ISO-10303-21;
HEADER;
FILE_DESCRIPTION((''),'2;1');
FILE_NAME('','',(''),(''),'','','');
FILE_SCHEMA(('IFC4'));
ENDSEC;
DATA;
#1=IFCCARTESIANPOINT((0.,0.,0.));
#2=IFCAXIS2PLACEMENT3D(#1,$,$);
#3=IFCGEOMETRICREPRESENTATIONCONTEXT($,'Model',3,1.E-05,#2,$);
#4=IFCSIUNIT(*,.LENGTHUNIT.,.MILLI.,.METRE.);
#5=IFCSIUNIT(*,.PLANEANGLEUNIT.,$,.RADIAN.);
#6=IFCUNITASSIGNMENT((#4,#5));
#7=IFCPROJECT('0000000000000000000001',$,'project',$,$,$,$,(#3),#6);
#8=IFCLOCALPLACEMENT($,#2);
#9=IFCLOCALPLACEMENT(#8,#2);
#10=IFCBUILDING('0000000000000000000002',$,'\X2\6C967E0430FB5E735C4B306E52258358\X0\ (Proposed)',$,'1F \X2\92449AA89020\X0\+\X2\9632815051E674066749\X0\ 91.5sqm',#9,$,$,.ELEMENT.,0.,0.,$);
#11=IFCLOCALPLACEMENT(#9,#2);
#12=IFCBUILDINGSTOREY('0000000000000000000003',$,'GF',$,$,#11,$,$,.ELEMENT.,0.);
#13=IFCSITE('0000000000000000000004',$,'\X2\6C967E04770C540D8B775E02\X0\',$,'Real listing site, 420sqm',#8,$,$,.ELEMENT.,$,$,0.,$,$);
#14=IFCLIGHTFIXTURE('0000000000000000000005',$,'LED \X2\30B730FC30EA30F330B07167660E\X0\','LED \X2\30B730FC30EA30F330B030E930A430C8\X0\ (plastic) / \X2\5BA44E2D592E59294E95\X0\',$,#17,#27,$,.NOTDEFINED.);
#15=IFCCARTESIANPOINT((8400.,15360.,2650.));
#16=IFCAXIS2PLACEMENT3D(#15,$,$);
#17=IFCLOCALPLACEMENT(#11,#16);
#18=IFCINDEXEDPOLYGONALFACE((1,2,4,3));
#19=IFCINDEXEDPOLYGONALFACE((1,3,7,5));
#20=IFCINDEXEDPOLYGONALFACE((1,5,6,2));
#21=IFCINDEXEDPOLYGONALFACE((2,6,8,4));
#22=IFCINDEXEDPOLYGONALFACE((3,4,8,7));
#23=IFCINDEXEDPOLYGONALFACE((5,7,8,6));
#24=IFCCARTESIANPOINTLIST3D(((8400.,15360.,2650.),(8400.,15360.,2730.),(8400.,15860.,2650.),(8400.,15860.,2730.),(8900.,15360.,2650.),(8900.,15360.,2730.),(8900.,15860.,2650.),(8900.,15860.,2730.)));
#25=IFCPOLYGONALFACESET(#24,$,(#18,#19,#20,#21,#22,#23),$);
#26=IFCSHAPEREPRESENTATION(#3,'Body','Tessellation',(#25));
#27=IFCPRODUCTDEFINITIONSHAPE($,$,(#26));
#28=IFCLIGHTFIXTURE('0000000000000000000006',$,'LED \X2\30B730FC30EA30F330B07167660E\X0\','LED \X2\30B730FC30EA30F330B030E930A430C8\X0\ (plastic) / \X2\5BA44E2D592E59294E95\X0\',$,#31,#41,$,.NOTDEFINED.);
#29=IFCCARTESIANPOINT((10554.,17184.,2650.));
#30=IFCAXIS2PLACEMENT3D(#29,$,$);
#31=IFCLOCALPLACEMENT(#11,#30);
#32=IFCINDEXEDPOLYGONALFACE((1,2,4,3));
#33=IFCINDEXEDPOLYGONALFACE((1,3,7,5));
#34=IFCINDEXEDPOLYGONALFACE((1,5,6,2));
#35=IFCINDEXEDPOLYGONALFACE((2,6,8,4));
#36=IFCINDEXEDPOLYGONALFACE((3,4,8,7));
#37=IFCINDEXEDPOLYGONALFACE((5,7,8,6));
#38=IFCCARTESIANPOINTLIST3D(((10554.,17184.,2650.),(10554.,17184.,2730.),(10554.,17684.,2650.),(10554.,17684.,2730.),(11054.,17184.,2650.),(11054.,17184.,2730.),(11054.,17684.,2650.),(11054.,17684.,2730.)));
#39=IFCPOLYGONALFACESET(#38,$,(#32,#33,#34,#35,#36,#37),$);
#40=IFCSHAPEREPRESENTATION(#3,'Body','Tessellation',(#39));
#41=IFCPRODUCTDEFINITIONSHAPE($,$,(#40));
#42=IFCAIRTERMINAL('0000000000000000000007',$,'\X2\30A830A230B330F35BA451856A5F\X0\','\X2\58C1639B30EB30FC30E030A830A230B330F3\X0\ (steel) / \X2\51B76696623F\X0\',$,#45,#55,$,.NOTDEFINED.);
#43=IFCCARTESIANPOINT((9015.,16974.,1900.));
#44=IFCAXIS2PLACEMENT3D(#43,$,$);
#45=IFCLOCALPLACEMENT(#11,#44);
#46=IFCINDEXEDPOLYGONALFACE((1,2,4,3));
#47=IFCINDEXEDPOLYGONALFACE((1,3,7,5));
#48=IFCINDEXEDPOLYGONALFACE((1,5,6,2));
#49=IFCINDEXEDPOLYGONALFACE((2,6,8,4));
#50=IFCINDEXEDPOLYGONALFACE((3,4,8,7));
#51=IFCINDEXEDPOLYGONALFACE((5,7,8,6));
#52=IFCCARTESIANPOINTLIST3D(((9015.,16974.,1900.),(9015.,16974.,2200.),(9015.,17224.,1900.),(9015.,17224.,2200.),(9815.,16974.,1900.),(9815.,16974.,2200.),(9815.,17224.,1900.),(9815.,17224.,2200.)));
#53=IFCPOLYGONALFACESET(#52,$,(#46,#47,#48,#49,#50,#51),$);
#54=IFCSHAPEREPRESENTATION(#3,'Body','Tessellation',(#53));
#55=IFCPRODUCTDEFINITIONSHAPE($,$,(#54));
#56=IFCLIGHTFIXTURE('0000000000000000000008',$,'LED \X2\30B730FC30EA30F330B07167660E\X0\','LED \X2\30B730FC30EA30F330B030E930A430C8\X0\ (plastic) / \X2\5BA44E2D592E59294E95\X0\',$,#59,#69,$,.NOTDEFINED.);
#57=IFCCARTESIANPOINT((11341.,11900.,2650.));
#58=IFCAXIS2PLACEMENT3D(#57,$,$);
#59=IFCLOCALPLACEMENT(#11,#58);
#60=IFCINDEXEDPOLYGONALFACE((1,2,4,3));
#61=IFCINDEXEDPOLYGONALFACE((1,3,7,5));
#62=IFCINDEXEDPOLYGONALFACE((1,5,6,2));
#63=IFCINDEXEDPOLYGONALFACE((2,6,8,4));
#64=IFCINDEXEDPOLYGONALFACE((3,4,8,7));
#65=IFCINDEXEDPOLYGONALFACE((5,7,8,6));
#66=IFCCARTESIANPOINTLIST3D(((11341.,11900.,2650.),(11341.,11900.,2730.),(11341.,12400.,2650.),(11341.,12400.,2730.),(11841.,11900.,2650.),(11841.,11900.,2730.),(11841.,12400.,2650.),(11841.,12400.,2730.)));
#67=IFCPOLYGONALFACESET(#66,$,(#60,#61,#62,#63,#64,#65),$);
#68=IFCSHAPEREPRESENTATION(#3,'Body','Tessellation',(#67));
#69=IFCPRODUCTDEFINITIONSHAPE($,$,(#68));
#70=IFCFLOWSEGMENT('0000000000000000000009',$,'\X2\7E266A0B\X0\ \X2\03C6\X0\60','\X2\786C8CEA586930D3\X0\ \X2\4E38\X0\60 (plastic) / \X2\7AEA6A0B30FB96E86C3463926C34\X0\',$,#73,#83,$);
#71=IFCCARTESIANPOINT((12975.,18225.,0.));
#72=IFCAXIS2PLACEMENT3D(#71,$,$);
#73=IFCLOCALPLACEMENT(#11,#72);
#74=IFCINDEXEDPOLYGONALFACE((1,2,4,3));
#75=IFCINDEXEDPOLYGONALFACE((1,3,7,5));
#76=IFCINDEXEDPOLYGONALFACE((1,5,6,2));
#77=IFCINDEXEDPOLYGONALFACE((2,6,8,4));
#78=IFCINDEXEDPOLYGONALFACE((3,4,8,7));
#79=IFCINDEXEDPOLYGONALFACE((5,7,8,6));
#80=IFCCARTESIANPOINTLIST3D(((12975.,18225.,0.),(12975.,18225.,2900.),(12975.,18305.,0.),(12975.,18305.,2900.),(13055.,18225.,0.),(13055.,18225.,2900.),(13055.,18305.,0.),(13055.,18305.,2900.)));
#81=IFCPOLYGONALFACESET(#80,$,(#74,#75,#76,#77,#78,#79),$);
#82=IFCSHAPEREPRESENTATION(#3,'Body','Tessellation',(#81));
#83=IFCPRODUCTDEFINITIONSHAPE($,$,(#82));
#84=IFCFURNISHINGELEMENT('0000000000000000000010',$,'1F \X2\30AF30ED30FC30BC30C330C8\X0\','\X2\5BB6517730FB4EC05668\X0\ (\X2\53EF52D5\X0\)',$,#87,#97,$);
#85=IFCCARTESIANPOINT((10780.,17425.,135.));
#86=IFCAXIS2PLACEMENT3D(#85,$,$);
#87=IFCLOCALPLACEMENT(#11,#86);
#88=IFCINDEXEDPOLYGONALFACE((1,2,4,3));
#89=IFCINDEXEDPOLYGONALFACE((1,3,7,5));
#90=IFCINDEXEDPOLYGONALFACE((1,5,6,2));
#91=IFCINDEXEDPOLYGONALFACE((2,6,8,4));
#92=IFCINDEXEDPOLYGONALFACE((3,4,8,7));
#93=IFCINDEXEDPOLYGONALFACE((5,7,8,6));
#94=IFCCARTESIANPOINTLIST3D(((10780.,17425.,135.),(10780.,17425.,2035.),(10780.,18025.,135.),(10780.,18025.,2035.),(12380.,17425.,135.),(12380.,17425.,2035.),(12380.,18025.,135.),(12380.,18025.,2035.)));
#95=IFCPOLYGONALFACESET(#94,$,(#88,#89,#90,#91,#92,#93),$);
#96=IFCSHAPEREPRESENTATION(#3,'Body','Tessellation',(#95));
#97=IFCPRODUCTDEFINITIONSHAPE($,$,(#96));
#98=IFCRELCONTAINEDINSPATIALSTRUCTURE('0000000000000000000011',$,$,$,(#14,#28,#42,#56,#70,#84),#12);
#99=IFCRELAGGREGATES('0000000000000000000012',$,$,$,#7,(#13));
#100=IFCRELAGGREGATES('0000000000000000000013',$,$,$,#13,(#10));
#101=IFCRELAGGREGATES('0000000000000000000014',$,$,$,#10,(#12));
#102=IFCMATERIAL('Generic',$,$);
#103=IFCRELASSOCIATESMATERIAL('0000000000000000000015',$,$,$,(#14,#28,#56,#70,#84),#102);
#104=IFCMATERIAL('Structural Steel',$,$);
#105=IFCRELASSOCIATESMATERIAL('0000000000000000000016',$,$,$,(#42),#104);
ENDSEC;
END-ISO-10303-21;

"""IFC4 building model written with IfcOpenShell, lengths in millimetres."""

from ifc_helpers import new_model, si_unit, frame, frame_2d, origin, place, context, project, spatial, rectangle, extrude, material, element, save


model = new_model("IFC4")

# Units and contexts
model_context = context("Model", 3, precision=1e-05, world=origin())
ifc_project = project(units=[si_unit("LENGTHUNIT", "METRE", prefix="MILLI"), si_unit("PLANEANGLEUNIT", "RADIAN")], contexts=[model_context])

# Site, building, storey
site_placement = place(None, origin())
site = spatial("IfcSite", under=ifc_project, at=site_placement, Name="沖縄県名護市", ObjectType="Real listing site, 420sqm", CompositionType="ELEMENT", RefElevation=0.0)
building_placement = place(site_placement, origin())
building = spatial("IfcBuilding", under=site, at=building_placement, Name="沖縄・平屋の別荘 (Proposed)", ObjectType="1F 鉄骨造+防腐処理杉 91.5sqm", CompositionType="ELEMENT", ElevationOfRefHeight=0.0, ElevationOfTerrain=0.0)
storey_placement = place(building_placement, origin())
storey = spatial("IfcBuildingStorey", under=building, at=storey_placement, Name="GF", CompositionType="ELEMENT", Elevation=0.0)

# Shared definitions
ifc_material_1 = material(Name="Generic")

# Shared definitions
ifc_material_2 = material(Name="Structural Steel")

# Light fixtures
light_fixture_1_placement = place(storey_placement, frame((8400.0, 15360.0, 2650.0)))
element("IfcLightFixture", 1, at=light_fixture_1_placement, inside=storey, material=ifc_material_1, Name="LED シーリング照明", Description="LED シーリングライト (plastic) / 室中央天井", PredefinedType="NOTDEFINED", context=model_context, shape_type="SweptSolid", body=[
    extrude(rectangle(XDim=500.0, YDim=500.0, at=frame_2d((250.0, 250.0))), frame((8400.0, 15360.0, 2650.0)), (0.0, 0.0, 1.0), 80.0),
])
light_fixture_2_placement = place(storey_placement, frame((10554.0, 17184.0, 2650.0)))
element("IfcLightFixture", 2, at=light_fixture_2_placement, inside=storey, material=ifc_material_1, Name="LED シーリング照明", Description="LED シーリングライト (plastic) / 室中央天井", PredefinedType="NOTDEFINED", context=model_context, shape_type="SweptSolid", body=[
    extrude(rectangle(XDim=500.0, YDim=500.0, at=frame_2d((250.0, 250.0))), frame((10554.0, 17184.0, 2650.0)), (0.0, 0.0, 1.0), 80.0),
])

# Air terminal
air_terminal_placement = place(storey_placement, frame((9015.0, 16974.0, 1900.0)))
element("IfcAirTerminal", 3, at=air_terminal_placement, inside=storey, material=ifc_material_2, Name="エアコン室内機", Description="壁掛ルームエアコン (steel) / 冷暖房", PredefinedType="NOTDEFINED", context=model_context, shape_type="SweptSolid", body=[
    extrude(rectangle(XDim=800.0, YDim=250.0, at=frame_2d((400.0, 125.0))), frame((9015.0, 16974.0, 1900.0)), (0.0, 0.0, 1.0), 300.0),
])

# Light fixture
light_fixture_3_placement = place(storey_placement, frame((11341.0, 11900.0, 2650.0)))
element("IfcLightFixture", 4, at=light_fixture_3_placement, inside=storey, material=ifc_material_1, Name="LED シーリング照明", Description="LED シーリングライト (plastic) / 室中央天井", PredefinedType="NOTDEFINED", context=model_context, shape_type="SweptSolid", body=[
    extrude(rectangle(XDim=500.0, YDim=500.0, at=frame_2d((250.0, 250.0))), frame((11341.0, 11900.0, 2650.0)), (0.0, 0.0, 1.0), 80.0),
])

# Flow segment
flow_segment_placement = place(storey_placement, frame((12975.0, 18225.0, 0.0)))
element("IfcFlowSegment", 5, at=flow_segment_placement, inside=storey, material=ifc_material_1, Name="縦樋 φ60", Description="硬質塩ビ 丸60 (plastic) / 竪樋・雨水排水", context=model_context, shape_type="SweptSolid", body=[
    extrude(rectangle(XDim=80.0, YDim=80.0, at=frame_2d((40.0, 40.0))), frame((12975.0, 18225.0, 0.0)), (0.0, 0.0, 1.0), 2900.0),
])

# Furnishing element
furnishing_placement = place(storey_placement, frame((10780.0, 17425.0, 135.0)))
element("IfcFurnishingElement", 6, at=furnishing_placement, inside=storey, material=ifc_material_1, Name="1F クローゼット", Description="家具・什器 (可動)", context=model_context, shape_type="SweptSolid", body=[
    extrude(rectangle(XDim=1600.0, YDim=600.0, at=frame_2d((800.0, 300.0))), frame((10780.0, 17425.0, 135.0)), (0.0, 0.0, 1.0), 1900.0),
])

save(model, "model.ifc")
